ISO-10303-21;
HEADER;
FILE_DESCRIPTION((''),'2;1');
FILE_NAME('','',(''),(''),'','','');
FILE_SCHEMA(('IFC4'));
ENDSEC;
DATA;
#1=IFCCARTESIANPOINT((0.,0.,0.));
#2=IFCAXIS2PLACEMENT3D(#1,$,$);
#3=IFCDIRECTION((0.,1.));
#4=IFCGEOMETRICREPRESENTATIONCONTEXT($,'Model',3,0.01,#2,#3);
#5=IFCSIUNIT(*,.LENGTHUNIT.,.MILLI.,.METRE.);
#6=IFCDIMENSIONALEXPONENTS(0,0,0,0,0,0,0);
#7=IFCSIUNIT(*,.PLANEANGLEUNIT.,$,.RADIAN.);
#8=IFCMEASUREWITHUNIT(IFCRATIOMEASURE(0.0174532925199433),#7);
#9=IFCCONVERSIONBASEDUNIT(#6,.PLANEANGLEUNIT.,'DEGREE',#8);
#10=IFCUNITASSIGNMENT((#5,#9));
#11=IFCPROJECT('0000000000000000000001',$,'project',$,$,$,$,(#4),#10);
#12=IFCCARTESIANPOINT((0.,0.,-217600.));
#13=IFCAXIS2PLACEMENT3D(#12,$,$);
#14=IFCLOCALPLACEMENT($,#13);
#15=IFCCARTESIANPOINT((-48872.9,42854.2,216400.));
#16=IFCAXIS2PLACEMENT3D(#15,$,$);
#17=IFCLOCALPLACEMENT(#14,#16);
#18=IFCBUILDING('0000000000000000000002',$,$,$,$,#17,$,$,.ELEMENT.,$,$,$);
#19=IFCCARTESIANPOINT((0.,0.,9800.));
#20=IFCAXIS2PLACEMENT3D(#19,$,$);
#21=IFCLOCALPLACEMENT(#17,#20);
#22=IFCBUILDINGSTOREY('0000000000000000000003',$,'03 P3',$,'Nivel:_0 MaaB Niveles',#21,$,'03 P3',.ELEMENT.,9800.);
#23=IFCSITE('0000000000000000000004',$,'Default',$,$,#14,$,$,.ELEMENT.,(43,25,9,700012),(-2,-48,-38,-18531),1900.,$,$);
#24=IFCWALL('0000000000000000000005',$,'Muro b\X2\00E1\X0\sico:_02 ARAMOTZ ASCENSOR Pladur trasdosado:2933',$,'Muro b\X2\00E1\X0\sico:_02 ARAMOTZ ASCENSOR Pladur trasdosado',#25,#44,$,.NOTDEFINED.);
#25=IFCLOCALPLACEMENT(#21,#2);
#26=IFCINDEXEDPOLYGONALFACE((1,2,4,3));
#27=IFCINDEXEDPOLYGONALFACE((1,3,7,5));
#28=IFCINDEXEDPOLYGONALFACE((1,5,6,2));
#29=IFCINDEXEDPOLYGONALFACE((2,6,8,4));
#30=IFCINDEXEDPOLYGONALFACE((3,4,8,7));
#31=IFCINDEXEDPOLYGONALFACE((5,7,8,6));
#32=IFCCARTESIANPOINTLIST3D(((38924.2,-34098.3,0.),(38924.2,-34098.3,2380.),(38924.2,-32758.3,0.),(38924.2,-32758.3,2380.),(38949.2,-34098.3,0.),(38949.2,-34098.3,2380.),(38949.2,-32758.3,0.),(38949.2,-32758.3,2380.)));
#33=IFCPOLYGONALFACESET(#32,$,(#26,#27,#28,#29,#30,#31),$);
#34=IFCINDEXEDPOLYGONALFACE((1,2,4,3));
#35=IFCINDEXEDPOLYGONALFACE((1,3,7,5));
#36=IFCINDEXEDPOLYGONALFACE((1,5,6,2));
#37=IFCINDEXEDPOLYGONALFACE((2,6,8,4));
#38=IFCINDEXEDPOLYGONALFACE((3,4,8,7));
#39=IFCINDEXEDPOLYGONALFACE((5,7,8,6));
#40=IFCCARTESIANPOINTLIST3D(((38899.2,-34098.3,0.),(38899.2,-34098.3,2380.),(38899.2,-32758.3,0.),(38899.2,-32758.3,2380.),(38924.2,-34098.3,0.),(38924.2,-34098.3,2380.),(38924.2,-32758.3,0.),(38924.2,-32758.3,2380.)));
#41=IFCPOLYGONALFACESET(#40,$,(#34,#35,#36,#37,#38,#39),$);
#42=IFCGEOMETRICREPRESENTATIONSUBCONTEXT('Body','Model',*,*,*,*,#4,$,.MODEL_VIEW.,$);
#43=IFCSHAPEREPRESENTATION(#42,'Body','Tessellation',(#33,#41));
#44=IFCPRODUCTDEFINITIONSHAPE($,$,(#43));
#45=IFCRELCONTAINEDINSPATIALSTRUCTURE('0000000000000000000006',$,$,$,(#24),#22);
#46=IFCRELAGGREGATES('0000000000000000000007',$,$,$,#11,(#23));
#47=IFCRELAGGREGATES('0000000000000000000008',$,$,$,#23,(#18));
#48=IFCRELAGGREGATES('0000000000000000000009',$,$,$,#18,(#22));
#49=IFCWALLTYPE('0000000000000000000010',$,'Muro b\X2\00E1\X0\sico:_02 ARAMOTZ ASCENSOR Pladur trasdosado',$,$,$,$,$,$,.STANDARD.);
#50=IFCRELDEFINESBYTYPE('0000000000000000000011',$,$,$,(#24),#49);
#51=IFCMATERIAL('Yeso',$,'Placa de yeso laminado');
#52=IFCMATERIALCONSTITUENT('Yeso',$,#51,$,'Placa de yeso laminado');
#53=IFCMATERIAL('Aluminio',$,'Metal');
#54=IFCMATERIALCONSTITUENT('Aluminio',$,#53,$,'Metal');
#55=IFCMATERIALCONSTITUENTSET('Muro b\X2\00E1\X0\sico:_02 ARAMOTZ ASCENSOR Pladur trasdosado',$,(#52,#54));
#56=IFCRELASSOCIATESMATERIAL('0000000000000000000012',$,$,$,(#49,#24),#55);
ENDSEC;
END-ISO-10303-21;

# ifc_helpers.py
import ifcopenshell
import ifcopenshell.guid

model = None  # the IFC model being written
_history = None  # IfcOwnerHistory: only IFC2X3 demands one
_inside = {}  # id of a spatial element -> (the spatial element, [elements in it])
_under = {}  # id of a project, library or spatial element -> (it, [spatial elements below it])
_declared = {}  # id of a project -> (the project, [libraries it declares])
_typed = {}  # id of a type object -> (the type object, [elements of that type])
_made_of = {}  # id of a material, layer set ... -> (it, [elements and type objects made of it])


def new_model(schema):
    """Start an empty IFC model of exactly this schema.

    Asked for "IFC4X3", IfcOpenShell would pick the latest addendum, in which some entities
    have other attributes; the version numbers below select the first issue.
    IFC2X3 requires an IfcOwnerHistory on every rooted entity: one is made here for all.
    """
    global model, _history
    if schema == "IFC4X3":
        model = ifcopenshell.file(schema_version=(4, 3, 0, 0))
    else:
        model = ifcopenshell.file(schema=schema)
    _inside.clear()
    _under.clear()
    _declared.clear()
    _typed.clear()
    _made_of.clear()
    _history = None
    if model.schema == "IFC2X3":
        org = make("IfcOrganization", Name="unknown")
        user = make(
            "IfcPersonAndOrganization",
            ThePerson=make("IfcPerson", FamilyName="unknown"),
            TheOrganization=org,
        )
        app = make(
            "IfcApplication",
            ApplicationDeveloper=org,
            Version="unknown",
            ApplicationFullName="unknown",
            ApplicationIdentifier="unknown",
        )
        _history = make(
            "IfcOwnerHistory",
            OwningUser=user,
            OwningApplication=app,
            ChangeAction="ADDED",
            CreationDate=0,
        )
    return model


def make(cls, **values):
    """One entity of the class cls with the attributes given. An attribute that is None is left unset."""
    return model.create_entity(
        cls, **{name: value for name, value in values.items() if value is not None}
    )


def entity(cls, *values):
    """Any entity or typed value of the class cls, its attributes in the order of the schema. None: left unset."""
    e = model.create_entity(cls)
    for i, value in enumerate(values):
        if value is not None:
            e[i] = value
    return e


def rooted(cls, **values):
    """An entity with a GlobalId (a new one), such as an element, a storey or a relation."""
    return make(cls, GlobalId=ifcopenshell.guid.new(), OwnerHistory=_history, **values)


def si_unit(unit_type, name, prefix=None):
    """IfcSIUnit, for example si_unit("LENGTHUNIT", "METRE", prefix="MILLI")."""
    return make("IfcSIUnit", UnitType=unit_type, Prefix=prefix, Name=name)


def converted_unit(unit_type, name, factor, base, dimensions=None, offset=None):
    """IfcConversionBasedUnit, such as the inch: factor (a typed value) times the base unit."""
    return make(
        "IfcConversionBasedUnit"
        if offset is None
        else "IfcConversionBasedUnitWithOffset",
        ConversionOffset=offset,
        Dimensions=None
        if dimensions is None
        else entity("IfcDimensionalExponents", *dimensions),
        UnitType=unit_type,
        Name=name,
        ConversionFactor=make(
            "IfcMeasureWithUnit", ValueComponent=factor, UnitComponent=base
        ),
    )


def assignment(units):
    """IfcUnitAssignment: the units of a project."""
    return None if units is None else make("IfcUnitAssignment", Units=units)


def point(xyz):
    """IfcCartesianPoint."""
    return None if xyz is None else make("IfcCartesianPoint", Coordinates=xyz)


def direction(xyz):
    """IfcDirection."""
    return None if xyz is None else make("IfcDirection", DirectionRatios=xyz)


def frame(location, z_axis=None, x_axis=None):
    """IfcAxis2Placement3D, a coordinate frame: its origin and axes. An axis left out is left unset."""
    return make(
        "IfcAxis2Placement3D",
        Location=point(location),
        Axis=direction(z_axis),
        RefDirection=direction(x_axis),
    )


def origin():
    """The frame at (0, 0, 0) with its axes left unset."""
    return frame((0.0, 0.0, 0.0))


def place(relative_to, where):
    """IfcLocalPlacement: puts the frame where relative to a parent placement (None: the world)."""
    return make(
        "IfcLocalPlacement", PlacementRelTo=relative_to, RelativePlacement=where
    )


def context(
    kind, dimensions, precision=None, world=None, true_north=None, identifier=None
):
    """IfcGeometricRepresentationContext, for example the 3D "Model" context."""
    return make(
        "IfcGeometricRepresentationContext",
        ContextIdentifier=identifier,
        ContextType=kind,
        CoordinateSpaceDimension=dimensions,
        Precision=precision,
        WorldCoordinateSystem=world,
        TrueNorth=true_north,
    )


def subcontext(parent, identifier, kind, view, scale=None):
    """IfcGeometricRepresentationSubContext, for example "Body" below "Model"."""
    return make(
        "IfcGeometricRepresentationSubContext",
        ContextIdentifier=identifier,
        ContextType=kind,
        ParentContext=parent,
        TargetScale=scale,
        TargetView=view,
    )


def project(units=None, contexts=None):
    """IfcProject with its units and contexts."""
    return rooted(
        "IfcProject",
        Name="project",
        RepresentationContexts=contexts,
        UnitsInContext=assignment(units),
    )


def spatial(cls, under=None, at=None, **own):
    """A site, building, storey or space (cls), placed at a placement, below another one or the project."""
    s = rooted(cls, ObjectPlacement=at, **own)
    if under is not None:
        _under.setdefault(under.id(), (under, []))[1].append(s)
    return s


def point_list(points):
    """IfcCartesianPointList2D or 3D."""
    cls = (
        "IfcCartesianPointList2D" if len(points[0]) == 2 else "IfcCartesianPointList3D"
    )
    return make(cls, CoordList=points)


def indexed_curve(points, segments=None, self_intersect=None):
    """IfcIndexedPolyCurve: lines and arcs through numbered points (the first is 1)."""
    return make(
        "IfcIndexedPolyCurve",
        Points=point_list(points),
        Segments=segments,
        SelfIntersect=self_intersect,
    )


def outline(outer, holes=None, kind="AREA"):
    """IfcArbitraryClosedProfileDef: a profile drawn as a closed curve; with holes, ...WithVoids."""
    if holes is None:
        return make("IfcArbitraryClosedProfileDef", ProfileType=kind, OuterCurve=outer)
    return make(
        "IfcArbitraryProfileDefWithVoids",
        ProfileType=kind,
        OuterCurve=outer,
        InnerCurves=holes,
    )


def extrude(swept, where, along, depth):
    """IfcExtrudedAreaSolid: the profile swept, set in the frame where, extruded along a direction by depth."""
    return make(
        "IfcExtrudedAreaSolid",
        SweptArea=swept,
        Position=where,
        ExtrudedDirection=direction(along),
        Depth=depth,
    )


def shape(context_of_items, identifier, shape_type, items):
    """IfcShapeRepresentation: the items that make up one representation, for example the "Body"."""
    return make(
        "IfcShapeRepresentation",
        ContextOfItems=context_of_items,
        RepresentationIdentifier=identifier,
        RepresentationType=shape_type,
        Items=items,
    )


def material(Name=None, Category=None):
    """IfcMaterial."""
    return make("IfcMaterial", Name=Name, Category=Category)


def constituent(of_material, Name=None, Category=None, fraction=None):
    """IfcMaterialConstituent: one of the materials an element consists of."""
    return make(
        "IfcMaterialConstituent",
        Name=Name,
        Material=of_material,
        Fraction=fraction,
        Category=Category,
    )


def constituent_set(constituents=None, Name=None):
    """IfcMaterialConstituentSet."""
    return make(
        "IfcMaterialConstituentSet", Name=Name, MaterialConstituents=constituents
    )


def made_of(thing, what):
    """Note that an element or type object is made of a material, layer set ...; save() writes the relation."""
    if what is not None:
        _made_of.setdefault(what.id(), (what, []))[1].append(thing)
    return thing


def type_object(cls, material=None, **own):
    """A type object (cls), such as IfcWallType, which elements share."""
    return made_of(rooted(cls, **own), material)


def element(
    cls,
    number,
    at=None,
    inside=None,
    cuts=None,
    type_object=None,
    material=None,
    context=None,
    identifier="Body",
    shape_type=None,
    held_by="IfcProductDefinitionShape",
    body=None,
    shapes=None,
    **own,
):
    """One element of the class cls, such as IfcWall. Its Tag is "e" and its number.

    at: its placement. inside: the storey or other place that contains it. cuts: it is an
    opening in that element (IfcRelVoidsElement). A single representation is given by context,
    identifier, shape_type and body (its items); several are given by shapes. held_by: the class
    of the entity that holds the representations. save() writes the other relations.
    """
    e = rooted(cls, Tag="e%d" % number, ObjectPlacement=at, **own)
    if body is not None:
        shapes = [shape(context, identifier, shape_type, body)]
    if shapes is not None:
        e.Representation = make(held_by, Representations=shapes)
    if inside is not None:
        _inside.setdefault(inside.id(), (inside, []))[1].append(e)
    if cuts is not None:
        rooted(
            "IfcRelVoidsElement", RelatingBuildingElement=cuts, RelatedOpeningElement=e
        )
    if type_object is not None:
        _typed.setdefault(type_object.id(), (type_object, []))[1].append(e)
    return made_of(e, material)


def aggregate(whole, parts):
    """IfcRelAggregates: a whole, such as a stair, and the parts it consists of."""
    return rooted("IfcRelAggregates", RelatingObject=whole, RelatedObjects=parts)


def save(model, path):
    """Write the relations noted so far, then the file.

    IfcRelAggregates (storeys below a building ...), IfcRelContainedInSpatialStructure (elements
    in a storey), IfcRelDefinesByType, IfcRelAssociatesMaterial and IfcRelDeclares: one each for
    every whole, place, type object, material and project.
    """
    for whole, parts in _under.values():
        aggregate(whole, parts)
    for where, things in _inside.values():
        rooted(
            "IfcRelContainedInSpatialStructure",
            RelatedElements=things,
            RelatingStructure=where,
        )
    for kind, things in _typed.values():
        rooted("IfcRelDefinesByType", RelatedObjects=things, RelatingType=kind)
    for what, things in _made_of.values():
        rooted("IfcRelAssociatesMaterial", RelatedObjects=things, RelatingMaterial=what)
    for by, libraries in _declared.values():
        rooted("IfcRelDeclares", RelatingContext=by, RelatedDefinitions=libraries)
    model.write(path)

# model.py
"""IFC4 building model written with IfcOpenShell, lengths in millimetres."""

from ifc_helpers import new_model, entity, si_unit, converted_unit, direction, frame, origin, place, context, subcontext, project, spatial, indexed_curve, outline, extrude, material, constituent, constituent_set, type_object, element, save


model = new_model("IFC4")

# Units and contexts
model_context = context("Model", 3, precision=0.01, world=origin(), true_north=direction((0.0, 1.0)))
body_context = subcontext(model_context, "Body", "Model", "MODEL_VIEW")
ifc_project = project(units=[si_unit("LENGTHUNIT", "METRE", prefix="MILLI"), converted_unit("PLANEANGLEUNIT", "DEGREE", entity("IfcRatioMeasure", 0.0174532925199433), si_unit("PLANEANGLEUNIT", "RADIAN"), dimensions=[0, 0, 0, 0, 0, 0, 0])], contexts=[model_context])

# Site, building, storey
site_placement = place(None, frame((0.0, 0.0, -217600.0)))
site = spatial("IfcSite", under=ifc_project, at=site_placement, Name="Default", CompositionType="ELEMENT", RefLatitude=(43, 25, 9, 700012), RefLongitude=(-2, -48, -38, -18531), RefElevation=1900.0)
building_placement = place(site_placement, frame((-48872.9, 42854.2, 216400.0)))
building = spatial("IfcBuilding", under=site, at=building_placement, CompositionType="ELEMENT")
storey_placement = place(building_placement, frame((0.0, 0.0, 9800.0)))
storey = spatial("IfcBuildingStorey", under=building, at=storey_placement, Name="03 P3", ObjectType="Nivel:_0 MaaB Niveles", LongName="03 P3", CompositionType="ELEMENT", Elevation=9800.0)

# Wall
ifc_material_1 = material(Name="Yeso", Category="Placa de yeso laminado")
ifc_material_2 = material(Name="Aluminio", Category="Metal")
ifc_constituent_1 = constituent(ifc_material_1, Name="Yeso", Category="Placa de yeso laminado")
ifc_constituent_2 = constituent(ifc_material_2, Name="Aluminio", Category="Metal")
ifc_constituent_set_1 = constituent_set(constituents=[ifc_constituent_1, ifc_constituent_2], Name="Muro básico:_02 ARAMOTZ ASCENSOR Pladur trasdosado")
wall_type_1 = type_object("IfcWallType", Name="Muro básico:_02 ARAMOTZ ASCENSOR Pladur trasdosado", PredefinedType="STANDARD", material=ifc_constituent_set_1)
wall_1_placement = place(storey_placement, frame((38924.2, -32758.3, 0.0), z_axis=(0.0, 0.0, 1.0), x_axis=(0.0, -1.0, 0.0)))
element("IfcWall", 1, at=wall_1_placement, inside=storey, type_object=wall_type_1, material=ifc_constituent_set_1, Name="Muro básico:_02 ARAMOTZ ASCENSOR Pladur trasdosado:2933", ObjectType="Muro básico:_02 ARAMOTZ ASCENSOR Pladur trasdosado", PredefinedType="NOTDEFINED", context=body_context, shape_type="SweptSolid", body=[
    extrude(outline(indexed_curve([(-670.0, -12.5), (670.0, -12.5), (670.0, 12.5), (-670.0, 12.5), (-670.0, -12.5)], self_intersect=False)), frame((670.0, 12.5, 0.0), z_axis=(0.0, 0.0, 1.0), x_axis=(-1.0, 0.0, 0.0)), (0.0, 0.0, 1.0), 2380.0),
    extrude(outline(indexed_curve([(-12.5, -670.0), (12.5, -670.0), (12.5, 670.0), (-12.5, 670.0), (-12.5, -670.0)], self_intersect=False)), frame((670.0, -12.5, 0.0), z_axis=(0.0, 0.0, 1.0), x_axis=(0.0, -1.0, 0.0)), (0.0, 0.0, 1.0), 2380.0),
])

save(model, "model.ifc")
